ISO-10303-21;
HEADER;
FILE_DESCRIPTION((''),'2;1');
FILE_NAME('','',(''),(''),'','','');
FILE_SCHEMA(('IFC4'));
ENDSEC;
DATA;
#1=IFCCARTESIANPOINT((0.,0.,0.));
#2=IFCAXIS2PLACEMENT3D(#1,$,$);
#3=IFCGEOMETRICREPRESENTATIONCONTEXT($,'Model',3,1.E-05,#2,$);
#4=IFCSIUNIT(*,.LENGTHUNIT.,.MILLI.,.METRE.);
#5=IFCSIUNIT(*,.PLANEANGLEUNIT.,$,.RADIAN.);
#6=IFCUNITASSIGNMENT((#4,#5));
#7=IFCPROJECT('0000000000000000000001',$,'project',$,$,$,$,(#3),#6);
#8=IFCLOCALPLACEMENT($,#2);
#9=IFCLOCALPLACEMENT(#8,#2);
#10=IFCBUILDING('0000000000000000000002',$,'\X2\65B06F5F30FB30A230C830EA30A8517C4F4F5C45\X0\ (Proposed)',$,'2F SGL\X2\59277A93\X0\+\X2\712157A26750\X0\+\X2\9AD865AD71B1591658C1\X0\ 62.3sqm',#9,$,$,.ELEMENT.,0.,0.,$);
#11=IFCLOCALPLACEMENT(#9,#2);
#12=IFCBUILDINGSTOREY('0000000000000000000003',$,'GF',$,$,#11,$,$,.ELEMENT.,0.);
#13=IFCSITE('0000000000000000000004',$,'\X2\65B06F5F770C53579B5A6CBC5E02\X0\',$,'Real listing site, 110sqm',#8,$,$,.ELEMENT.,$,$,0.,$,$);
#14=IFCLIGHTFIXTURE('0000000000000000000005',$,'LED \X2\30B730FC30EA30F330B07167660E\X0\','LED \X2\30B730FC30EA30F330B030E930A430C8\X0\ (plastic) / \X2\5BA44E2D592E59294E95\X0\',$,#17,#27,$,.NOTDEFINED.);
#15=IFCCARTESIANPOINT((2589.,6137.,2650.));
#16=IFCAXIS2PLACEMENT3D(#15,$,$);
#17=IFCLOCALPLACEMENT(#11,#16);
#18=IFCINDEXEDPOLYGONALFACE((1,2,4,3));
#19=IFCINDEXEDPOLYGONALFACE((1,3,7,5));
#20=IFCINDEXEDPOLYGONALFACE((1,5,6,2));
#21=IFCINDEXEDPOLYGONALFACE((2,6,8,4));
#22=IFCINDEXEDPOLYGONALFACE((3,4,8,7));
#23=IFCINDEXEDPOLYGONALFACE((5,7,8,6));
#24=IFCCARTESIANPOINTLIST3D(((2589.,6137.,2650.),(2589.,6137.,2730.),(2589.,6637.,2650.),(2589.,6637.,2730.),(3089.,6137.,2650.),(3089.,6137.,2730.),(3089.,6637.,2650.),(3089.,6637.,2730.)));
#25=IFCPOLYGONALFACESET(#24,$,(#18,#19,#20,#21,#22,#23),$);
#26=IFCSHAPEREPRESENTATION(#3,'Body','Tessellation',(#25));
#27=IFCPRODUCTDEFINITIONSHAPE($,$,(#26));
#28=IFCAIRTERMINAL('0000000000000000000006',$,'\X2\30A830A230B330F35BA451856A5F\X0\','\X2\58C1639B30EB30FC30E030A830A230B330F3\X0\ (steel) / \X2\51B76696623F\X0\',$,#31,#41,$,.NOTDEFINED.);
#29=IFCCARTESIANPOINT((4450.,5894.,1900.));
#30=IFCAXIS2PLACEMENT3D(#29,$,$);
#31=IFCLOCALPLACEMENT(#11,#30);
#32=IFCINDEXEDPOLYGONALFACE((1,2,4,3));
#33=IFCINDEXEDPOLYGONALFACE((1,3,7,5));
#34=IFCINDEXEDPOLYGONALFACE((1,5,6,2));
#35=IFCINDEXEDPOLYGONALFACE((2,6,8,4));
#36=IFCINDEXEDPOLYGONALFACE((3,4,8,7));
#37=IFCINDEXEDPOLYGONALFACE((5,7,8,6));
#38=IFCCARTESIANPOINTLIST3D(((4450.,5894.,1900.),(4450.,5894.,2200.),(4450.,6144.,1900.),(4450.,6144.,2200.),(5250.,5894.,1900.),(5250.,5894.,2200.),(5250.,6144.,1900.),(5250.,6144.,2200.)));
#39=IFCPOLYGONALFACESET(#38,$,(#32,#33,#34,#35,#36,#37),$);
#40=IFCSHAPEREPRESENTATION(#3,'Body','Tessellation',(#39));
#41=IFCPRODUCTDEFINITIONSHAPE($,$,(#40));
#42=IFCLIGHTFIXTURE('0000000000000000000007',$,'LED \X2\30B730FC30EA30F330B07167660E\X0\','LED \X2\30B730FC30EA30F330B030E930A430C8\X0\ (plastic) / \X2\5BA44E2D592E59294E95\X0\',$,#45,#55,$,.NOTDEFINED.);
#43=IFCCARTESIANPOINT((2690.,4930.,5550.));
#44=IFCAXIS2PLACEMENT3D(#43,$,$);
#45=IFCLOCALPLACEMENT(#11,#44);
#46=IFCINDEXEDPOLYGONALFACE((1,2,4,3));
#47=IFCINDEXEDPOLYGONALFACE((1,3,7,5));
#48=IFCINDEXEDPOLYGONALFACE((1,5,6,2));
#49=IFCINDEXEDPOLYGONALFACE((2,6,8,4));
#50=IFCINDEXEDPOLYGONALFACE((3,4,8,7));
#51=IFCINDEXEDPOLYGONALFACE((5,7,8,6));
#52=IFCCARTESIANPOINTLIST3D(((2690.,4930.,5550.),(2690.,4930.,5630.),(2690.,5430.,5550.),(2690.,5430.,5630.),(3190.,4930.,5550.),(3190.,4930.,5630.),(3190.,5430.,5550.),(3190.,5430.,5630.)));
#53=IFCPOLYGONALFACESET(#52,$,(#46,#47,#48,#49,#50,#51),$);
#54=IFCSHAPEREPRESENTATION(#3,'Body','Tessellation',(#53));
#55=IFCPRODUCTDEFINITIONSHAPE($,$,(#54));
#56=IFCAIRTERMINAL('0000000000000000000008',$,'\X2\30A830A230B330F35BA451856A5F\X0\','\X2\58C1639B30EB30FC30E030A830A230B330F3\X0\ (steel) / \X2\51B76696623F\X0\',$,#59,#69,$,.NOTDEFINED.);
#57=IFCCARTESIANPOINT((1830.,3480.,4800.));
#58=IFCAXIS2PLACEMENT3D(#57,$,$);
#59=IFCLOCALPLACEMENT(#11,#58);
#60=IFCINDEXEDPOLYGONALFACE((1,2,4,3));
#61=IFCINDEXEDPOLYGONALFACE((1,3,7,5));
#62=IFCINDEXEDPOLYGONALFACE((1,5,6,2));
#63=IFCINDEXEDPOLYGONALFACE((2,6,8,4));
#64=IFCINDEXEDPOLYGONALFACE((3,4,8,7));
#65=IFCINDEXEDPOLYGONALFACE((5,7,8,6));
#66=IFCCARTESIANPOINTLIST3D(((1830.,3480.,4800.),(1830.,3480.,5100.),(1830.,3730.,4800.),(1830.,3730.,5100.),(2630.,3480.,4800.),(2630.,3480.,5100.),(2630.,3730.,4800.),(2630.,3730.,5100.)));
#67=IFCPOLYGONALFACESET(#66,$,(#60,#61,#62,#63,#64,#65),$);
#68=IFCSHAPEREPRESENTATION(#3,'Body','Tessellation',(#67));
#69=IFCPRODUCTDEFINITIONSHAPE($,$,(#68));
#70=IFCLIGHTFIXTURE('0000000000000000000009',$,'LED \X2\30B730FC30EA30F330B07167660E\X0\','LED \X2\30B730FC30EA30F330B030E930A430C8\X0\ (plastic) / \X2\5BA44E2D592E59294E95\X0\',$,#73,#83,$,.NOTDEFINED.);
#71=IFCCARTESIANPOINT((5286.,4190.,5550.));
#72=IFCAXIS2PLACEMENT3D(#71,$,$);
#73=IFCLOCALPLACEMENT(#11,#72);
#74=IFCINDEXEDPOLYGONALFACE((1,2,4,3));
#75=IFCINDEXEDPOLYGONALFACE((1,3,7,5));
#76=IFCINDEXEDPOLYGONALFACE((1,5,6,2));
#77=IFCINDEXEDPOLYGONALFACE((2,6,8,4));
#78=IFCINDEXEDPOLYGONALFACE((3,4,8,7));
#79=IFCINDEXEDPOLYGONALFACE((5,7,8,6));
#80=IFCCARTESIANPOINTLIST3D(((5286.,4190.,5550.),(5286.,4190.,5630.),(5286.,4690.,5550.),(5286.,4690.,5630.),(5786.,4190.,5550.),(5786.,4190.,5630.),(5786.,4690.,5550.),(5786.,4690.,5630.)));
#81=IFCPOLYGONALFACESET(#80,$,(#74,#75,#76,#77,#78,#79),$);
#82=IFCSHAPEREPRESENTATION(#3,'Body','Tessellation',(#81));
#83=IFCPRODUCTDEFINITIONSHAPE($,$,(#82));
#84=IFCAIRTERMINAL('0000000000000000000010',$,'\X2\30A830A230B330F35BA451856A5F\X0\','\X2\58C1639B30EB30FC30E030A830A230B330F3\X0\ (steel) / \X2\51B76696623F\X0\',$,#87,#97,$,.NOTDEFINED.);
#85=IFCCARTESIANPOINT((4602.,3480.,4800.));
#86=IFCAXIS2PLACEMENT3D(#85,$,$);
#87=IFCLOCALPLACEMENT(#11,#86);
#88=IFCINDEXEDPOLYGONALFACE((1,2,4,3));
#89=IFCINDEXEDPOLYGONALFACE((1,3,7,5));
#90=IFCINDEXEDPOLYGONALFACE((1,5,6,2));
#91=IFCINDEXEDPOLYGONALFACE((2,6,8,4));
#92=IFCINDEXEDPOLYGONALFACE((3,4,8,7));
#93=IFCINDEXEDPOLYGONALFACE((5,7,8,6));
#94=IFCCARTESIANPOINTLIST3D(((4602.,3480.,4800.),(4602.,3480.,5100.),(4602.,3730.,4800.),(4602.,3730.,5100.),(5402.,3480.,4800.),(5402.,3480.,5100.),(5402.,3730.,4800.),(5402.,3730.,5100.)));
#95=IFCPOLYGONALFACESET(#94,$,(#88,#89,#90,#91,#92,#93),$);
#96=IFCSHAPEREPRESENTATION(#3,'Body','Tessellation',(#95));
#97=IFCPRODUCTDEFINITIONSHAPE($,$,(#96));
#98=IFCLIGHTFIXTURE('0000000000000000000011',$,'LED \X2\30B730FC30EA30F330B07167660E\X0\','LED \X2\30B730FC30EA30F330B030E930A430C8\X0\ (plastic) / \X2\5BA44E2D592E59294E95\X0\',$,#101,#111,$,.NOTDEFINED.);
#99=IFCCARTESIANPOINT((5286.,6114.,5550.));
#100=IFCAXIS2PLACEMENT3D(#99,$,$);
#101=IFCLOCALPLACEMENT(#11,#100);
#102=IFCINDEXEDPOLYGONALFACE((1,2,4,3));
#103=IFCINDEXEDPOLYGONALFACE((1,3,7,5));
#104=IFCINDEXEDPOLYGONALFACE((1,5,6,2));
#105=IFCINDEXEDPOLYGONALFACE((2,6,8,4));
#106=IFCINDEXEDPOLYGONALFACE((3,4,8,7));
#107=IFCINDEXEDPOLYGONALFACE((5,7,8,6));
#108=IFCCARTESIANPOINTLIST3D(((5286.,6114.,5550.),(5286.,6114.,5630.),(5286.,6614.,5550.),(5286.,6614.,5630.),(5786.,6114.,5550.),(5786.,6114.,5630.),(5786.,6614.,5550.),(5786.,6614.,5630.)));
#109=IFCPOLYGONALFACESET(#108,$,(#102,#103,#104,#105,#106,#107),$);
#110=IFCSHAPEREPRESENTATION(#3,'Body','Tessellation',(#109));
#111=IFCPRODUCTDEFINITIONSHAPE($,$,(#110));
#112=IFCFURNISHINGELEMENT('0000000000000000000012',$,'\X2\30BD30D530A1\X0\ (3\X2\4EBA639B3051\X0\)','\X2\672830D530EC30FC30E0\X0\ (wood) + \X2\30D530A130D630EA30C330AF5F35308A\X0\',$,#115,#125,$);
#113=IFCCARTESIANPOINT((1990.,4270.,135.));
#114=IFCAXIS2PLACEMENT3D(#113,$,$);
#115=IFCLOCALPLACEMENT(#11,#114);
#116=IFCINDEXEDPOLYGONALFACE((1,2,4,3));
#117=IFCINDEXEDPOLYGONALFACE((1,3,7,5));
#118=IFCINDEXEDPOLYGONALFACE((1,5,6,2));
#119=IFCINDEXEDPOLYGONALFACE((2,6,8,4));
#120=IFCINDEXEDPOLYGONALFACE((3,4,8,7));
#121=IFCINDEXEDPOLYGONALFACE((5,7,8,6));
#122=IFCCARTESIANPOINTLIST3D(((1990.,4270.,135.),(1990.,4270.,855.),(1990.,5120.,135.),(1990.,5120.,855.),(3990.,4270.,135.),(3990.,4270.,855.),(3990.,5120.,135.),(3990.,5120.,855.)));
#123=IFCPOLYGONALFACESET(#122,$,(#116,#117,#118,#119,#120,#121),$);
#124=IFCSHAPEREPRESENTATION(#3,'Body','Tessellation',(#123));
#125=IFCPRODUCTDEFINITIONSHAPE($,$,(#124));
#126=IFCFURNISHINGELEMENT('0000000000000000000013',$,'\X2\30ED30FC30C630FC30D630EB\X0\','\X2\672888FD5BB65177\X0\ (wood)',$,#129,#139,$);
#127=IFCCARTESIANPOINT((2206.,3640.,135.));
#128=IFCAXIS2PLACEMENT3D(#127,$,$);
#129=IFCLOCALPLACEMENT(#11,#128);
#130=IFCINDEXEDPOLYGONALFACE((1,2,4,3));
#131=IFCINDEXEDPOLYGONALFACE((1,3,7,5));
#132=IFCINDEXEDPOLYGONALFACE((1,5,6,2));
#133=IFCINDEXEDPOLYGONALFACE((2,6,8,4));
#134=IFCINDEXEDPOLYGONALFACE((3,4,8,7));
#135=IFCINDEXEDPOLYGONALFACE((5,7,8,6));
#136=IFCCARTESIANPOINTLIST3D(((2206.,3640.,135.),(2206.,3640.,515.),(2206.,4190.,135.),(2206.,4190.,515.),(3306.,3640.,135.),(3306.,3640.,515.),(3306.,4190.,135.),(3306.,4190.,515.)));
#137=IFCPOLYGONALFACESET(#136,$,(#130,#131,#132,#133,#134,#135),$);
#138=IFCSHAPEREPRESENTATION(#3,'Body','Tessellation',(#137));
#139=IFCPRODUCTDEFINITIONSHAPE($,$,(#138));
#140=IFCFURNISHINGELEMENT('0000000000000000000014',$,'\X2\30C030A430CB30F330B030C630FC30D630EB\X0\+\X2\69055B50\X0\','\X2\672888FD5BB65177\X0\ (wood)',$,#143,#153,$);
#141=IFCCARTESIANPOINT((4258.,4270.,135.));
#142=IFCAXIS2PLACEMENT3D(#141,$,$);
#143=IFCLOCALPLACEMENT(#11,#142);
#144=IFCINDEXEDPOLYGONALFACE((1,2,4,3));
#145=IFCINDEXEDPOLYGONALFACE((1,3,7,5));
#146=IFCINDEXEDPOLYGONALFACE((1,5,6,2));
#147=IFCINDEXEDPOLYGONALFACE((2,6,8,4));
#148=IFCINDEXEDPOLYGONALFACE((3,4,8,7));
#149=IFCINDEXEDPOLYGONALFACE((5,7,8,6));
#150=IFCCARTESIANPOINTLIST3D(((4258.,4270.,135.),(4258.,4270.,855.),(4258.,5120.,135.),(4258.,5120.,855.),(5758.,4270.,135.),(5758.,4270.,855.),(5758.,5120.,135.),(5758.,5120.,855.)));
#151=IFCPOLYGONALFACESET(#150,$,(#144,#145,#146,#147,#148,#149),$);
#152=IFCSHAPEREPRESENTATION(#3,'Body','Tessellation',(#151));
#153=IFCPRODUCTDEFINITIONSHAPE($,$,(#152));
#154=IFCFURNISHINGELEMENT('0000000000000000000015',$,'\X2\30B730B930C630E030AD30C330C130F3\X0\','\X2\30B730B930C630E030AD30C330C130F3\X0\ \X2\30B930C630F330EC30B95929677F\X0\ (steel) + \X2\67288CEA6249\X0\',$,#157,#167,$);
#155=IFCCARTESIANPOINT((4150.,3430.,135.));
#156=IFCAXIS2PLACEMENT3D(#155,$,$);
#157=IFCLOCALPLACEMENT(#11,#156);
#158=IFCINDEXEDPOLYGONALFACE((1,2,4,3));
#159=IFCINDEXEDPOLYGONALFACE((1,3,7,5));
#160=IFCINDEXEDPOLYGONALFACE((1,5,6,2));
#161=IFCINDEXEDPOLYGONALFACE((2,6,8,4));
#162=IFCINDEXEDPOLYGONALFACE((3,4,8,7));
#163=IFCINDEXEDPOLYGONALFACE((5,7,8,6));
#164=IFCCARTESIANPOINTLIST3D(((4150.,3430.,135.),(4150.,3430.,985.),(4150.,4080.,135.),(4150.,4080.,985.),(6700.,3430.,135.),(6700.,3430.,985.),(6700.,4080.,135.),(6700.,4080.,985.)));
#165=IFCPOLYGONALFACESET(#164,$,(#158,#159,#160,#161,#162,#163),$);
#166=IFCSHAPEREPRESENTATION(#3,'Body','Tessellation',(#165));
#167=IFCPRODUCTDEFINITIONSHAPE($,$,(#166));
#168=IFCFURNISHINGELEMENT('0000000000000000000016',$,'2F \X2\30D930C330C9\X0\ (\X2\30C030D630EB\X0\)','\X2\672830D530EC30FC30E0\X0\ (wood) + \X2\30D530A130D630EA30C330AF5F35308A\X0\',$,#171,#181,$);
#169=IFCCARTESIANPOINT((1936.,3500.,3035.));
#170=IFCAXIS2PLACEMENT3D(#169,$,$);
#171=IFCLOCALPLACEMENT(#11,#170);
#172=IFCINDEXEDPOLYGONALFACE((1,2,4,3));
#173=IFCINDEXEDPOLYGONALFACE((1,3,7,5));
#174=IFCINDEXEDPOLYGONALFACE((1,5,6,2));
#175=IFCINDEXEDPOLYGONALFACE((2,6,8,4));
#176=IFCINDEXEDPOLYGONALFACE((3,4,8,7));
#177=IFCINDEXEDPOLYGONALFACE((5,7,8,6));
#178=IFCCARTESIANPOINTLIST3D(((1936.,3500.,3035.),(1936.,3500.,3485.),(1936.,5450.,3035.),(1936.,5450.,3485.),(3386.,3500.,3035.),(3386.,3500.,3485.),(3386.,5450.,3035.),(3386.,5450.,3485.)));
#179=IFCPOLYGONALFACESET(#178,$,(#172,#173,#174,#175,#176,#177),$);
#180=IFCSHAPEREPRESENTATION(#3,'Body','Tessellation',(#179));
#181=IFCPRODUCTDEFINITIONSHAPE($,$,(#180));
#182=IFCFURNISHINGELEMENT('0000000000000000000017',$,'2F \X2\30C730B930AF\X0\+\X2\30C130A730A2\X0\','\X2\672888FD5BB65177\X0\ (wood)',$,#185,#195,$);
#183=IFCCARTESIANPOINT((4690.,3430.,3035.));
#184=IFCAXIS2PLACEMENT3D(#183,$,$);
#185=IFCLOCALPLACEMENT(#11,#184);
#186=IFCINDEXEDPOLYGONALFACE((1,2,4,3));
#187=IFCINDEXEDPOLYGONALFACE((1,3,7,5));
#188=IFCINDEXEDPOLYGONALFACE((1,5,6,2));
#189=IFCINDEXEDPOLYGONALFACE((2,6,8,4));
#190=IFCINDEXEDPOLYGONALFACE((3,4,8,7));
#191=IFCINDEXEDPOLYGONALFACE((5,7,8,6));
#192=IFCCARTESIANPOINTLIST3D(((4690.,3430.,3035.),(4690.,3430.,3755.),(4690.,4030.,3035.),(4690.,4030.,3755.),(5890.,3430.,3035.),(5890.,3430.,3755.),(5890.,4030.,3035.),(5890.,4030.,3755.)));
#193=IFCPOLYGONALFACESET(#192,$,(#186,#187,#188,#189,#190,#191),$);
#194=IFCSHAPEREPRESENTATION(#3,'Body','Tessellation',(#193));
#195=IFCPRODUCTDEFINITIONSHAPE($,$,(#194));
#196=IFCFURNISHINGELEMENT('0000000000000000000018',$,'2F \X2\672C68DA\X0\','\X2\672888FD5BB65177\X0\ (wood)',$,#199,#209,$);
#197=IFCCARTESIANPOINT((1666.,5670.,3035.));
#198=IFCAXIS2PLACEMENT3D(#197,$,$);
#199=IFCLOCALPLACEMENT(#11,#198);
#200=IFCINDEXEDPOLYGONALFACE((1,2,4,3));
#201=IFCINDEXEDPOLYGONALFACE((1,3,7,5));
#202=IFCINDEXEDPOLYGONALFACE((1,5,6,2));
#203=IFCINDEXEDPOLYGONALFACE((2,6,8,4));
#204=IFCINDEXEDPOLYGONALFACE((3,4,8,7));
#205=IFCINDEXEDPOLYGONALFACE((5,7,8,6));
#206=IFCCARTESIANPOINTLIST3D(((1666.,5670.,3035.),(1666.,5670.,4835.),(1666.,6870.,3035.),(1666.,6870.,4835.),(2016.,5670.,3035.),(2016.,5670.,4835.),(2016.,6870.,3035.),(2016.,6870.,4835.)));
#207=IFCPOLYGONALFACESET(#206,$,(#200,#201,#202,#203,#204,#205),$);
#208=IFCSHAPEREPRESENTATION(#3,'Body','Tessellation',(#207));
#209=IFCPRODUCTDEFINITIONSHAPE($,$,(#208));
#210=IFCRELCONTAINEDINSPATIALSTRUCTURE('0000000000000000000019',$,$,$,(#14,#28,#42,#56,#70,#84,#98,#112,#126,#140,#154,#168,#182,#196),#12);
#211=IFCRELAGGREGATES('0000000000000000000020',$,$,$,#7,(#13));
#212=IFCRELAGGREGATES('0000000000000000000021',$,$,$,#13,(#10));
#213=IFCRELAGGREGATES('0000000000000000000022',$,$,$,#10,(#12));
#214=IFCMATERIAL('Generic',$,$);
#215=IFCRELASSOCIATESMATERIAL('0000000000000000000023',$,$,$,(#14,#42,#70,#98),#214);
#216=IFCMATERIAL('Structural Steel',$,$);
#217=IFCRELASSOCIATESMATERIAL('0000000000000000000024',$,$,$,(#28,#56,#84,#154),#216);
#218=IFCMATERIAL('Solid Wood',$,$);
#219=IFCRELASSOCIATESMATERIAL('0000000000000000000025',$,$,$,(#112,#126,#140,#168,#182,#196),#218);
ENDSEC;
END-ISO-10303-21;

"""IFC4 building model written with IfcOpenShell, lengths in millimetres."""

from ifc_helpers import new_model, si_unit, frame, frame_2d, origin, place, context, project, spatial, rectangle, extrude, material, element, save


model = new_model("IFC4")

# Units and contexts
model_context = context("Model", 3, precision=1e-05, world=origin())
ifc_project = project(units=[si_unit("LENGTHUNIT", "METRE", prefix="MILLI"), si_unit("PLANEANGLEUNIT", "RADIAN")], contexts=[model_context])

# Site, building, storey
site_placement = place(None, origin())
site = spatial("IfcSite", under=ifc_project, at=site_placement, Name="新潟県南魚沼市", ObjectType="Real listing site, 110sqm", CompositionType="ELEMENT", RefElevation=0.0)
building_placement = place(site_placement, origin())
building = spatial("IfcBuilding", under=site, at=building_placement, Name="新潟・アトリエ兼住居 (Proposed)", ObjectType="2F SGL大窓+無垢材+高断熱外壁 62.3sqm", CompositionType="ELEMENT", ElevationOfRefHeight=0.0, ElevationOfTerrain=0.0)
storey_placement = place(building_placement, origin())
storey = spatial("IfcBuildingStorey", under=building, at=storey_placement, Name="GF", CompositionType="ELEMENT", Elevation=0.0)

# Shared definitions
ifc_material_1 = material(Name="Solid Wood")

# Shared definitions
ifc_material_2 = material(Name="Structural Steel")

# Shared definitions
ifc_material_3 = material(Name="Generic")

# Light fixture
light_fixture_1_placement = place(storey_placement, frame((2589.0, 6137.0, 2650.0)))
element("IfcLightFixture", 1, at=light_fixture_1_placement, inside=storey, material=ifc_material_3, Name="LED シーリング照明", Description="LED シーリングライト (plastic) / 室中央天井", PredefinedType="NOTDEFINED", context=model_context, shape_type="SweptSolid", body=[
    extrude(rectangle(XDim=500.0, YDim=500.0, at=frame_2d((250.0, 250.0))), frame((2589.0, 6137.0, 2650.0)), (0.0, 0.0, 1.0), 80.0),
])

# Air terminal
air_terminal_1_placement = place(storey_placement, frame((4450.0, 5894.0, 1900.0)))
element("IfcAirTerminal", 2, at=air_terminal_1_placement, inside=storey, material=ifc_material_2, Name="エアコン室内機", Description="壁掛ルームエアコン (steel) / 冷暖房", PredefinedType="NOTDEFINED", context=model_context, shape_type="SweptSolid", body=[
    extrude(rectangle(XDim=800.0, YDim=250.0, at=frame_2d((400.0, 125.0))), frame((4450.0, 5894.0, 1900.0)), (0.0, 0.0, 1.0), 300.0),
])

# Light fixture
light_fixture_2_placement = place(storey_placement, frame((2690.0, 4930.0, 5550.0)))
element("IfcLightFixture", 3, at=light_fixture_2_placement, inside=storey, material=ifc_material_3, Name="LED シーリング照明", Description="LED シーリングライト (plastic) / 室中央天井", PredefinedType="NOTDEFINED", context=model_context, shape_type="SweptSolid", body=[
    extrude(rectangle(XDim=500.0, YDim=500.0, at=frame_2d((250.0, 250.0))), frame((2690.0, 4930.0, 5550.0)), (0.0, 0.0, 1.0), 80.0),
])

# Air terminal
air_terminal_2_placement = place(storey_placement, frame((1830.0, 3480.0, 4800.0)))
element("IfcAirTerminal", 4, at=air_terminal_2_placement, inside=storey, material=ifc_material_2, Name="エアコン室内機", Description="壁掛ルームエアコン (steel) / 冷暖房", PredefinedType="NOTDEFINED", context=model_context, shape_type="SweptSolid", body=[
    extrude(rectangle(XDim=800.0, YDim=250.0, at=frame_2d((400.0, 125.0))), frame((1830.0, 3480.0, 4800.0)), (0.0, 0.0, 1.0), 300.0),
])

# Light fixture
light_fixture_3_placement = place(storey_placement, frame((5286.0, 4190.0, 5550.0)))
element("IfcLightFixture", 5, at=light_fixture_3_placement, inside=storey, material=ifc_material_3, Name="LED シーリング照明", Description="LED シーリングライト (plastic) / 室中央天井", PredefinedType="NOTDEFINED", context=model_context, shape_type="SweptSolid", body=[
    extrude(rectangle(XDim=500.0, YDim=500.0, at=frame_2d((250.0, 250.0))), frame((5286.0, 4190.0, 5550.0)), (0.0, 0.0, 1.0), 80.0),
])

# Air terminal
air_terminal_3_placement = place(storey_placement, frame((4602.0, 3480.0, 4800.0)))
element("IfcAirTerminal", 6, at=air_terminal_3_placement, inside=storey, material=ifc_material_2, Name="エアコン室内機", Description="壁掛ルームエアコン (steel) / 冷暖房", PredefinedType="NOTDEFINED", context=model_context, shape_type="SweptSolid", body=[
    extrude(rectangle(XDim=800.0, YDim=250.0, at=frame_2d((400.0, 125.0))), frame((4602.0, 3480.0, 4800.0)), (0.0, 0.0, 1.0), 300.0),
])

# Light fixture
light_fixture_4_placement = place(storey_placement, frame((5286.0, 6114.0, 5550.0)))
element("IfcLightFixture", 7, at=light_fixture_4_placement, inside=storey, material=ifc_material_3, Name="LED シーリング照明", Description="LED シーリングライト (plastic) / 室中央天井", PredefinedType="NOTDEFINED", context=model_context, shape_type="SweptSolid", body=[
    extrude(rectangle(XDim=500.0, YDim=500.0, at=frame_2d((250.0, 250.0))), frame((5286.0, 6114.0, 5550.0)), (0.0, 0.0, 1.0), 80.0),
])

# Furnishing elements
furnishing_1_placement = place(storey_placement, frame((1990.0, 4270.0, 135.0)))
element("IfcFurnishingElement", 8, at=furnishing_1_placement, inside=storey, material=ifc_material_1, Name="ソファ (3人掛け)", Description="木フレーム (wood) + ファブリック張り", context=model_context, shape_type="SweptSolid", body=[
    extrude(rectangle(XDim=2000.0, YDim=850.0, at=frame_2d((1000.0, 425.0))), frame((1990.0, 4270.0, 135.0)), (0.0, 0.0, 1.0), 720.0),
])
furnishing_2_placement = place(storey_placement, frame((2206.0, 3640.0, 135.0)))
element("IfcFurnishingElement", 9, at=furnishing_2_placement, inside=storey, material=ifc_material_1, Name="ローテーブル", Description="木製家具 (wood)", context=model_context, shape_type="SweptSolid", body=[
    extrude(rectangle(XDim=1100.0, YDim=550.0, at=frame_2d((550.0, 275.0))), frame((2206.0, 3640.0, 135.0)), (0.0, 0.0, 1.0), 380.0),
])
furnishing_3_placement = place(storey_placement, frame((4258.0, 4270.0, 135.0)))
element("IfcFurnishingElement", 10, at=furnishing_3_placement, inside=storey, material=ifc_material_1, Name="ダイニングテーブル+椅子", Description="木製家具 (wood)", context=model_context, shape_type="SweptSolid", body=[
    extrude(rectangle(XDim=1500.0, YDim=850.0, at=frame_2d((750.0, 425.0))), frame((4258.0, 4270.0, 135.0)), (0.0, 0.0, 1.0), 720.0),
])
furnishing_4_placement = place(storey_placement, frame((4150.0, 3430.0, 135.0)))
element("IfcFurnishingElement", 11, at=furnishing_4_placement, inside=storey, material=ifc_material_2, Name="システムキッチン", Description="システムキッチン ステンレス天板 (steel) + 木質扉", context=model_context, shape_type="SweptSolid", body=[
    extrude(rectangle(XDim=2550.0, YDim=650.0, at=frame_2d((1275.0, 325.0))), frame((4150.0, 3430.0, 135.0)), (0.0, 0.0, 1.0), 850.0),
])
furnishing_5_placement = place(storey_placement, frame((1936.0, 3500.0, 3035.0)))
element("IfcFurnishingElement", 12, at=furnishing_5_placement, inside=storey, material=ifc_material_1, Name="2F ベッド (ダブル)", Description="木フレーム (wood) + ファブリック張り", context=model_context, shape_type="SweptSolid", body=[
    extrude(rectangle(XDim=1450.0, YDim=1950.0, at=frame_2d((725.0, 975.0))), frame((1936.0, 3500.0, 3035.0)), (0.0, 0.0, 1.0), 450.0),
])
furnishing_6_placement = place(storey_placement, frame((4690.0, 3430.0, 3035.0)))
element("IfcFurnishingElement", 13, at=furnishing_6_placement, inside=storey, material=ifc_material_1, Name="2F デスク+チェア", Description="木製家具 (wood)", context=model_context, shape_type="SweptSolid", body=[
    extrude(rectangle(XDim=1200.0, YDim=600.0, at=frame_2d((600.0, 300.0))), frame((4690.0, 3430.0, 3035.0)), (0.0, 0.0, 1.0), 720.0),
])
furnishing_7_placement = place(storey_placement, frame((1666.0, 5670.0, 3035.0)))
element("IfcFurnishingElement", 14, at=furnishing_7_placement, inside=storey, material=ifc_material_1, Name="2F 本棚", Description="木製家具 (wood)", context=model_context, shape_type="SweptSolid", body=[
    extrude(rectangle(XDim=350.0, YDim=1200.0, at=frame_2d((175.0, 600.0))), frame((1666.0, 5670.0, 3035.0)), (0.0, 0.0, 1.0), 1800.0),
])

save(model, "model.ifc")
